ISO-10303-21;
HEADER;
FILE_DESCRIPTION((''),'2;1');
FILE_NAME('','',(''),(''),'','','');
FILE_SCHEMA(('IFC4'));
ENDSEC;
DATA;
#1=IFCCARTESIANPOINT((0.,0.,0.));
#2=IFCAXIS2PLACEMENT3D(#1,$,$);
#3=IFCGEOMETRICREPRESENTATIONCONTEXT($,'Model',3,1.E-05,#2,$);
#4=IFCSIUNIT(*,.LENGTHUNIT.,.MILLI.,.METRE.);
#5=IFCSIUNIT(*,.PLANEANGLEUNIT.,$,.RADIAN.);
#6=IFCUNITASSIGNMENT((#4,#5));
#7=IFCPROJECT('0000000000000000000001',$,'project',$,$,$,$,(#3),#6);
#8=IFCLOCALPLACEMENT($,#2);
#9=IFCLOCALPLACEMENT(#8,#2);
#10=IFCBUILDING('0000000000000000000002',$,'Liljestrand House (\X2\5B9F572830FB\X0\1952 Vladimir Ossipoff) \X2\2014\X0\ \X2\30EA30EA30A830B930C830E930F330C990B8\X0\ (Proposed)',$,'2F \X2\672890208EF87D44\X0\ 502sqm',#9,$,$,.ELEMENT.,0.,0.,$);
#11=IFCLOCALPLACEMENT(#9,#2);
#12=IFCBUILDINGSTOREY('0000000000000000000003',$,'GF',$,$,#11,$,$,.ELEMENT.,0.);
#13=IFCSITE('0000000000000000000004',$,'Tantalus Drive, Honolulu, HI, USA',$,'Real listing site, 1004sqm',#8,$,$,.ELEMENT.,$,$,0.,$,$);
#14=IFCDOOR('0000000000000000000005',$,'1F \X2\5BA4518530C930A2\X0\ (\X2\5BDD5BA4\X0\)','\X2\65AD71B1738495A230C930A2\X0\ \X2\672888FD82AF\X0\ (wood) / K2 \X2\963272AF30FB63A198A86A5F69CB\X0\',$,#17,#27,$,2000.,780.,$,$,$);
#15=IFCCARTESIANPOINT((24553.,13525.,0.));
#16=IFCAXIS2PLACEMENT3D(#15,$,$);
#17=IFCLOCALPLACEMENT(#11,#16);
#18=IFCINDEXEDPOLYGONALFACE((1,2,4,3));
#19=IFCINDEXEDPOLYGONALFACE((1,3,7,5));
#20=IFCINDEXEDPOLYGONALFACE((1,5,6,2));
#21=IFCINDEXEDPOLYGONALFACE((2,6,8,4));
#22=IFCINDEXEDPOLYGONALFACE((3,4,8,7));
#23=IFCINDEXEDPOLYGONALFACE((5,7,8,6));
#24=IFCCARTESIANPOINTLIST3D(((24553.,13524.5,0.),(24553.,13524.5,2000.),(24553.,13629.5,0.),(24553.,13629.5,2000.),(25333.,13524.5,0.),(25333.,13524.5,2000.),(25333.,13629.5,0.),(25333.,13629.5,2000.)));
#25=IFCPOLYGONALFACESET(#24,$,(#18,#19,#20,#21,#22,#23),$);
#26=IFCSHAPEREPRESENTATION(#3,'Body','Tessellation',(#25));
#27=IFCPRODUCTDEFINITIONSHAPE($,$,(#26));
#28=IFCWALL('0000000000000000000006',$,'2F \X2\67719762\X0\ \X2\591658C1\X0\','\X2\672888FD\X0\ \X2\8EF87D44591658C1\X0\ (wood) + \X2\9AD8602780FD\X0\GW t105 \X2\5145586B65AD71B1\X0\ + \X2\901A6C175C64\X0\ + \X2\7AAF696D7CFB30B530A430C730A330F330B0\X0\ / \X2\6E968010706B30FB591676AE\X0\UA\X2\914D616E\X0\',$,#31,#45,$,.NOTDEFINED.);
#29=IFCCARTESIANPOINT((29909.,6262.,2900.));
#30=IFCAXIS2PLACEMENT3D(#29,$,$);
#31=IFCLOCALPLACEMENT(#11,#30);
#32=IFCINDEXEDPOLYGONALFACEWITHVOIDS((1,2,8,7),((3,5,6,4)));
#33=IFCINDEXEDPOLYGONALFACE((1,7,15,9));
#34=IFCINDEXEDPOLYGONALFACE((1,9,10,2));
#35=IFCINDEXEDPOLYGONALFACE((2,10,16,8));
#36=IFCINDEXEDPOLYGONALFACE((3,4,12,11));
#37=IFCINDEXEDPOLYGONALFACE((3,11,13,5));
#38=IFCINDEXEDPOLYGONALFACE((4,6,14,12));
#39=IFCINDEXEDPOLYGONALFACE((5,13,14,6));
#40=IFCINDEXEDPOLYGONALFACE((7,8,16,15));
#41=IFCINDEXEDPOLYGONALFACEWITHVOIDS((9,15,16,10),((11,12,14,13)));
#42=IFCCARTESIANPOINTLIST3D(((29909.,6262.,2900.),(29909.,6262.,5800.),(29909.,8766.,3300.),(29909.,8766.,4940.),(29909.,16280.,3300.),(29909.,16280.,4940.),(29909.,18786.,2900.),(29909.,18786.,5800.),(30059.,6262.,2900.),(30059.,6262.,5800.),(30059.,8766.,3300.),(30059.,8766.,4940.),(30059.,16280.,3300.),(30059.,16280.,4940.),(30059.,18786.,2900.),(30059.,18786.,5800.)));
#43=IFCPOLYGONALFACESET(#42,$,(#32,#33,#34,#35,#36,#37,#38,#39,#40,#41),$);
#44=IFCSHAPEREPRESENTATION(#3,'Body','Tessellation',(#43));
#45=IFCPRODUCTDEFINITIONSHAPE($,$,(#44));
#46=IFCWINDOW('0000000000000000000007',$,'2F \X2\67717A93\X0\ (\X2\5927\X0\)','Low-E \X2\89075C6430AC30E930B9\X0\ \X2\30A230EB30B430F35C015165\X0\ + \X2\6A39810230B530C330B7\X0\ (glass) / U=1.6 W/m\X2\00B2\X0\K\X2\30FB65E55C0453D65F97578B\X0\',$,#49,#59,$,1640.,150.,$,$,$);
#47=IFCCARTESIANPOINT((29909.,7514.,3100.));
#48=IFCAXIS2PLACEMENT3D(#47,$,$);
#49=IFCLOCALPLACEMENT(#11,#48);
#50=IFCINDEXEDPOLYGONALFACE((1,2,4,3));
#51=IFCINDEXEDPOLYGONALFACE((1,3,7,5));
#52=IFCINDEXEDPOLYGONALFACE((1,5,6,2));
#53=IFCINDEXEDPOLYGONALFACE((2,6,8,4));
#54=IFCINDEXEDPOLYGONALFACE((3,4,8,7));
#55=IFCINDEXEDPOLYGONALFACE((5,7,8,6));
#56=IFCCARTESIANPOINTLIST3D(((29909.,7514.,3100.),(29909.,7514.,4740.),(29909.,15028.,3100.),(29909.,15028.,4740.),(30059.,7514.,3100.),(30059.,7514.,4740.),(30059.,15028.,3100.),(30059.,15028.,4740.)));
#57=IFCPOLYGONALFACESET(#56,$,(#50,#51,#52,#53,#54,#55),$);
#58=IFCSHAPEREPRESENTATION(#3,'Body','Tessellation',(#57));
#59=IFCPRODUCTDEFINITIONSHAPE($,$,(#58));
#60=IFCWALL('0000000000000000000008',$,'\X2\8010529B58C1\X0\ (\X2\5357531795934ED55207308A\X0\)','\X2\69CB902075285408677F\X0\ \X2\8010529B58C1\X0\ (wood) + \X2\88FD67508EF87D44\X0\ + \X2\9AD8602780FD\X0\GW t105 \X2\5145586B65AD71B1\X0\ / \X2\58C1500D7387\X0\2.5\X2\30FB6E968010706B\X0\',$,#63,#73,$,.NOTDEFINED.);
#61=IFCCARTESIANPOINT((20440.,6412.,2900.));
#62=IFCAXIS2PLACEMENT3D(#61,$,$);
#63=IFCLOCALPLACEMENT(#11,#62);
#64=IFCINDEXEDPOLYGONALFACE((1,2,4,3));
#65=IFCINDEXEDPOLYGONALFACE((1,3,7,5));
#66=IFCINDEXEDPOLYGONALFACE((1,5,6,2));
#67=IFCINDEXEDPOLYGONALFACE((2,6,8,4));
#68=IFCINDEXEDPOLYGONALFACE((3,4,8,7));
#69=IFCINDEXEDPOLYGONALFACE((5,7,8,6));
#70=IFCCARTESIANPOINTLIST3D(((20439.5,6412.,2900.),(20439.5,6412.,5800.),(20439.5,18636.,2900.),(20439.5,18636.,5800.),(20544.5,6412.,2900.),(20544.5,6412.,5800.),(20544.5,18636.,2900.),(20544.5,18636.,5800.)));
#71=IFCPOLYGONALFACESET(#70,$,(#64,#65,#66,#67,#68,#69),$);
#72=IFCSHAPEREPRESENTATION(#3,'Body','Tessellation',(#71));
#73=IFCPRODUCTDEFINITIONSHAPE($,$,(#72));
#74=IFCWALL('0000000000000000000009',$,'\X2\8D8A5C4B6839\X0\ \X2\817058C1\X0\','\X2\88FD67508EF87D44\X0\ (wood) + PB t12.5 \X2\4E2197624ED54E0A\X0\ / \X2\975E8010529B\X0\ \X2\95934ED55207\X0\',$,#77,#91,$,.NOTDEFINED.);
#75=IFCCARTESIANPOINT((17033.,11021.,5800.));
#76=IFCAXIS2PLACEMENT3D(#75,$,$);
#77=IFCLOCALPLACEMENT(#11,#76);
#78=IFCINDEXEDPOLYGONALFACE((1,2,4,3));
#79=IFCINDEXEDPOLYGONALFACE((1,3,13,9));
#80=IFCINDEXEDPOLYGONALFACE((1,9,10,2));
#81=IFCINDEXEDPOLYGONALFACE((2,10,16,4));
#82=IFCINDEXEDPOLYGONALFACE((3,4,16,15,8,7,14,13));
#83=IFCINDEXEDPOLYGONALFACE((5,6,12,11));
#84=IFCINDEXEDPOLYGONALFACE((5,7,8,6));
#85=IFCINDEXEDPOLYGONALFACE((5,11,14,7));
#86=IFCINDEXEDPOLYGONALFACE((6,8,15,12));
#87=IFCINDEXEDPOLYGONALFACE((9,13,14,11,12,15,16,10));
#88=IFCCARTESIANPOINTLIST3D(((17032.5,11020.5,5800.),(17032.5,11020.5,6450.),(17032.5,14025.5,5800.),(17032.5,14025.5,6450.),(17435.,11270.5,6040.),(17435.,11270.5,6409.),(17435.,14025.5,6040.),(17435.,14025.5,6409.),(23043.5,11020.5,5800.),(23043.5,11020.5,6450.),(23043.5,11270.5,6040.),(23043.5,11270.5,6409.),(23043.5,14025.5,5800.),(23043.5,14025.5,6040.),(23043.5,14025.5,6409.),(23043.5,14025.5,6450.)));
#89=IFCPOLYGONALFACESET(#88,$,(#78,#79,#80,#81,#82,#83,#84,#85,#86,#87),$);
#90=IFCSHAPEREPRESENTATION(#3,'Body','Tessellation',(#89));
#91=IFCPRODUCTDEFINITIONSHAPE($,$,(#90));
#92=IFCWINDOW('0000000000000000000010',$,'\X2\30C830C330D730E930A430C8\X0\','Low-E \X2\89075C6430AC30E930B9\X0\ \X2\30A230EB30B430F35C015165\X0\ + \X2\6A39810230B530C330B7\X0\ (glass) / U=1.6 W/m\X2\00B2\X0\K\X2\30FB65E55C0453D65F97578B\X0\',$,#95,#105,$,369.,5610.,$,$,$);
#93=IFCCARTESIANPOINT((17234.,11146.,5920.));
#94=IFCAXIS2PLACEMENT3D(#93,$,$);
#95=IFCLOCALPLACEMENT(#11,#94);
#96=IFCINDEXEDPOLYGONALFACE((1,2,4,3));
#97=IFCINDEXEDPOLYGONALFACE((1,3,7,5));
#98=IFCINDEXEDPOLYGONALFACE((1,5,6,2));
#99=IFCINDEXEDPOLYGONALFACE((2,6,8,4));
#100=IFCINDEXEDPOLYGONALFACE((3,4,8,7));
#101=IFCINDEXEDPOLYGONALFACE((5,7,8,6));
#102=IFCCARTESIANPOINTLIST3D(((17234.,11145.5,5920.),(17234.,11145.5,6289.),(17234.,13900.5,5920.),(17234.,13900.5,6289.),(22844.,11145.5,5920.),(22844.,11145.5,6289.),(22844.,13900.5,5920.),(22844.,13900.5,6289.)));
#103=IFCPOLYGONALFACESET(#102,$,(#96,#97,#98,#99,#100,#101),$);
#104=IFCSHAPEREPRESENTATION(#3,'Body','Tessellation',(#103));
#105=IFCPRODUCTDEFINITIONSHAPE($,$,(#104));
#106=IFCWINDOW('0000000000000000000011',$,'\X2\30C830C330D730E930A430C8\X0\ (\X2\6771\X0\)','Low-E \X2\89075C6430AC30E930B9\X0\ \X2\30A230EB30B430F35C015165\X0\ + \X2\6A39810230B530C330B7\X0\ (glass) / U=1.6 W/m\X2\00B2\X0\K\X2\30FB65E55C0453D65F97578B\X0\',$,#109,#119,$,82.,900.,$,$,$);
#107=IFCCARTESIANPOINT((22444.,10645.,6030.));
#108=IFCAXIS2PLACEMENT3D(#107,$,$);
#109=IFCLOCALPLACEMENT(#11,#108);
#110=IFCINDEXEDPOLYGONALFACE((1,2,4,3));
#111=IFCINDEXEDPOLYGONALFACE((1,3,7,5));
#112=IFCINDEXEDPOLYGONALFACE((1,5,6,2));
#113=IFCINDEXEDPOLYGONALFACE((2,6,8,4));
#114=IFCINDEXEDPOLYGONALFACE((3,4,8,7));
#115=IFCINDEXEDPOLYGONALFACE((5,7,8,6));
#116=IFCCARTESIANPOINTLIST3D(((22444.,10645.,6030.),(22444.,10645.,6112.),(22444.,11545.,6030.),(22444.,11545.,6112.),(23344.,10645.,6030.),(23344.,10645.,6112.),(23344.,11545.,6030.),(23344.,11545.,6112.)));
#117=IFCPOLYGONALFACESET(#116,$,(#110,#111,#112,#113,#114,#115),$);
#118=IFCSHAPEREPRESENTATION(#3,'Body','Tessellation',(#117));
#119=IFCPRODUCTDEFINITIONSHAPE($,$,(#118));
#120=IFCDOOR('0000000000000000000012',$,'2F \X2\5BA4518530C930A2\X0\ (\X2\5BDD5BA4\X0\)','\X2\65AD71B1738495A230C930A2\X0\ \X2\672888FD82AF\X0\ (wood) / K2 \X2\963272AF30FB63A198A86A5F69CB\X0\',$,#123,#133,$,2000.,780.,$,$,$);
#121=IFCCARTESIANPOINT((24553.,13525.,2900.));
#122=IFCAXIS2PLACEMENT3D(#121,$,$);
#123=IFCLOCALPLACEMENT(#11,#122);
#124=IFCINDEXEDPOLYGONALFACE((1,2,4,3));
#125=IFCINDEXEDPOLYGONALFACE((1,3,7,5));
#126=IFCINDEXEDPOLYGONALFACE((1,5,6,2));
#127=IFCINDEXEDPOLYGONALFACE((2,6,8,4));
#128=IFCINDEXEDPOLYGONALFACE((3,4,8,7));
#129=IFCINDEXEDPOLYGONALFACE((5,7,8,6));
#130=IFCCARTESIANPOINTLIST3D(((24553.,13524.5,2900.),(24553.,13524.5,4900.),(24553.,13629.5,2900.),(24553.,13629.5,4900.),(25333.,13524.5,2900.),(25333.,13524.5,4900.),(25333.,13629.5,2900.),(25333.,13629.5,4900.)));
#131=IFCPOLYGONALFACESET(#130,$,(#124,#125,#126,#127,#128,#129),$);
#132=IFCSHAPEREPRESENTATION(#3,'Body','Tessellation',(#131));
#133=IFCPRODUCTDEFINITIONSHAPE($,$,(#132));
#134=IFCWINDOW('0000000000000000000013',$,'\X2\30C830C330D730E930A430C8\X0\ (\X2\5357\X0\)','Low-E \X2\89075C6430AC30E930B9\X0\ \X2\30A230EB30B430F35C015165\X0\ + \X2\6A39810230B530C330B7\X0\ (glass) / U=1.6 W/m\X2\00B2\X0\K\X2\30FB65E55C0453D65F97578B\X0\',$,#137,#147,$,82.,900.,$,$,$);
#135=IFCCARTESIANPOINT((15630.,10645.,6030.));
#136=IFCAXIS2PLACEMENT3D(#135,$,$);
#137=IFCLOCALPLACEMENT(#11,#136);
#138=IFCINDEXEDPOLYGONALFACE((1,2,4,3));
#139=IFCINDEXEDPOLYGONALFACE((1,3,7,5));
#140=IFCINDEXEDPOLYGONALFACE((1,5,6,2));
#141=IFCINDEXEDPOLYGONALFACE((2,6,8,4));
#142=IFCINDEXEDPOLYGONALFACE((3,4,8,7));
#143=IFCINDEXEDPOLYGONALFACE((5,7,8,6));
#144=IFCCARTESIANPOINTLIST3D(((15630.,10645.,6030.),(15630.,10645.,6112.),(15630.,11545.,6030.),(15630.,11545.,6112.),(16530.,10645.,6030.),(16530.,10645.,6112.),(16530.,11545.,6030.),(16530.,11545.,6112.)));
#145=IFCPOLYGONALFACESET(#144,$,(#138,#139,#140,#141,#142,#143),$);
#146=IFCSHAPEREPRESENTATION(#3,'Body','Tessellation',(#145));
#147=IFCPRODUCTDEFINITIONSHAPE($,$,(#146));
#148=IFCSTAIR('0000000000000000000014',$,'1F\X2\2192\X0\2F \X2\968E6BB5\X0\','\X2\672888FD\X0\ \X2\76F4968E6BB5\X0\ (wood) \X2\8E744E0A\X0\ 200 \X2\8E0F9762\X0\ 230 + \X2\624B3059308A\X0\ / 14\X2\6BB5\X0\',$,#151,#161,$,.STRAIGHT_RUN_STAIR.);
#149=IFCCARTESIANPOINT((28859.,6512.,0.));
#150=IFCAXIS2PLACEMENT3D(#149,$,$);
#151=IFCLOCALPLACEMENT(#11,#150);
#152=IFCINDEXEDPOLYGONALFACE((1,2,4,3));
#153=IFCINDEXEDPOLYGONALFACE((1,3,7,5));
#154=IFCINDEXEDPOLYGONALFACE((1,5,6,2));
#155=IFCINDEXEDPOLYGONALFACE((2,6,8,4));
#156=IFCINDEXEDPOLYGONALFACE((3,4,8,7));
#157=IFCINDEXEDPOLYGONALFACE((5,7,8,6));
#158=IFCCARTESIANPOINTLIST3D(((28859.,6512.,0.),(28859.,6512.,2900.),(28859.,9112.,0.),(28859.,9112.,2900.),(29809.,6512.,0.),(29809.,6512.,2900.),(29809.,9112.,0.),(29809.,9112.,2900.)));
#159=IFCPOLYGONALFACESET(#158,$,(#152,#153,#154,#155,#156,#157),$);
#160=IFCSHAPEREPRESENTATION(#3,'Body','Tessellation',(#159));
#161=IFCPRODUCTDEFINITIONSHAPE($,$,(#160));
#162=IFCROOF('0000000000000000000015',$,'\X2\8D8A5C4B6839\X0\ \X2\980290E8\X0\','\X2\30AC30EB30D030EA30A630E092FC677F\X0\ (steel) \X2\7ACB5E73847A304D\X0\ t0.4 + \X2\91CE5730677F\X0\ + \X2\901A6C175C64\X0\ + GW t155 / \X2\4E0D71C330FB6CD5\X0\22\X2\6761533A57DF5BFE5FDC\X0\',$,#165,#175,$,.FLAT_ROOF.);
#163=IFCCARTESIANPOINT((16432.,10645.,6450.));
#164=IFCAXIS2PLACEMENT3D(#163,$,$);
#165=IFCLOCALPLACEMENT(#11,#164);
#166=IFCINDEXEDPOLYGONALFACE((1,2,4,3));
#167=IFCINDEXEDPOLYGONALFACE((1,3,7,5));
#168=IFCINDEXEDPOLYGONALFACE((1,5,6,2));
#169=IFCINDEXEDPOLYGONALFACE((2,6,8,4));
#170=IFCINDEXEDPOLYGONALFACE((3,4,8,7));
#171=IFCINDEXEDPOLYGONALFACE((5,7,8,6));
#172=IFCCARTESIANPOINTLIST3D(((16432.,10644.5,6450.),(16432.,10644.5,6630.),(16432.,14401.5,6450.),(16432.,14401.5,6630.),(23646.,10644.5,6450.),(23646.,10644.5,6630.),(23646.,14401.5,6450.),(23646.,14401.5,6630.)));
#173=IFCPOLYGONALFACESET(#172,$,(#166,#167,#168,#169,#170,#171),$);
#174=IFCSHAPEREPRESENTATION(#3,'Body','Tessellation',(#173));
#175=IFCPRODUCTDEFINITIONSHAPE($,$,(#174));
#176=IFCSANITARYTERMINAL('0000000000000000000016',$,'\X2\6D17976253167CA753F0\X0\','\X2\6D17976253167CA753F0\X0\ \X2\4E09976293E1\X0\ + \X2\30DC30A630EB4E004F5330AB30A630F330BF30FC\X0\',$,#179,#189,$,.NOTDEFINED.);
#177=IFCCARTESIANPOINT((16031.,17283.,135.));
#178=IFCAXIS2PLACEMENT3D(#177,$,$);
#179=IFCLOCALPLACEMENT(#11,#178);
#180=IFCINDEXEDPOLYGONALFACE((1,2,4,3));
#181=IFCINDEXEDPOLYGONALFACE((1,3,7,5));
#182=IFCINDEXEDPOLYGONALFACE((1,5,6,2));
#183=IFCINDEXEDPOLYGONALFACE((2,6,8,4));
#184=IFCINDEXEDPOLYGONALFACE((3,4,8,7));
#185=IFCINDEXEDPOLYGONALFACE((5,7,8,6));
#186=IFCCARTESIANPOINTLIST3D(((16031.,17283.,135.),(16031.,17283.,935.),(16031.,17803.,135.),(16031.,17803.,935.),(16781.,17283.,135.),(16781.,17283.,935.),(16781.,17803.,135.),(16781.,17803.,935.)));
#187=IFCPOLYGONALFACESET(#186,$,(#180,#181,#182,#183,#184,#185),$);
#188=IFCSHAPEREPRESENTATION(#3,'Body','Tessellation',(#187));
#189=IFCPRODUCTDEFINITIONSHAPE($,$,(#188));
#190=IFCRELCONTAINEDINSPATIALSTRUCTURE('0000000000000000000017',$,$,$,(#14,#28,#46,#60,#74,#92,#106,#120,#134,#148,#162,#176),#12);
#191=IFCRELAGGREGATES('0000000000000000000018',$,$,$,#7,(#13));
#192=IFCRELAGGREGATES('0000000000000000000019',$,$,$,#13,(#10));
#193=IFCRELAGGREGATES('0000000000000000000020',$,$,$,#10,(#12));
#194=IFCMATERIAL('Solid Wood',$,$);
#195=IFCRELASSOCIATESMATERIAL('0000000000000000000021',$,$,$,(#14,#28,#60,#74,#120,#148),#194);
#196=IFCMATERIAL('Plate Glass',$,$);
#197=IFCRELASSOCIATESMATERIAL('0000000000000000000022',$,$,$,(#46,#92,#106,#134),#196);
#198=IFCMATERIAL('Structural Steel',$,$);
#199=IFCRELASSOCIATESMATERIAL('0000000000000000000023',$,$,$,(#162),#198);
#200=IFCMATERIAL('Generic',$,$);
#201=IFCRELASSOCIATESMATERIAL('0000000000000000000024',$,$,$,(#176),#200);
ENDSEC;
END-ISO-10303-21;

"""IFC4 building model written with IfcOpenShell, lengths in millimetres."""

from ifc_helpers import new_model, si_unit, frame, frame_2d, origin, place, context, project, spatial, rectangle, extrude, material, element, fill, save


model = new_model("IFC4")

# Units and contexts
model_context = context("Model", 3, precision=1e-05, world=origin())
ifc_project = project(units=[si_unit("LENGTHUNIT", "METRE", prefix="MILLI"), si_unit("PLANEANGLEUNIT", "RADIAN")], contexts=[model_context])

# Site, building, storey
site_placement = place(None, origin())
site = spatial("IfcSite", under=ifc_project, at=site_placement, Name="Tantalus Drive, Honolulu, HI, USA", ObjectType="Real listing site, 1004sqm", CompositionType="ELEMENT", RefElevation=0.0)
building_placement = place(site_placement, origin())
building = spatial("IfcBuilding", under=site, at=building_placement, Name="Liljestrand House (実在・1952 Vladimir Ossipoff) — リリエストランド邸 (Proposed)", ObjectType="2F 木造軸組 502sqm", CompositionType="ELEMENT", ElevationOfRefHeight=0.0, ElevationOfTerrain=0.0)
storey_placement = place(building_placement, origin())
storey = spatial("IfcBuildingStorey", under=building, at=storey_placement, Name="GF", CompositionType="ELEMENT", Elevation=0.0)

# Shared definitions
ifc_material_1 = material(Name="Solid Wood")
ifc_material_2 = material(Name="Plate Glass")

# Door
door_1_placement = place(storey_placement, frame((24553.0, 13525.0, 0.0)))
element("IfcDoor", 1, at=door_1_placement, inside=storey, material=ifc_material_1, Name="1F 室内ドア (寝室)", Description="断熱玄関ドア 木製芯 (wood) / K2 防犯・採風機構", OverallHeight=2000.0, OverallWidth=780.0, context=model_context, shape_type="SweptSolid", body=[
    extrude(rectangle(XDim=780.0, YDim=105.0, at=frame_2d((390.0, 52.0))), frame((24553.0, 13525.0, 0.0)), (0.0, 0.0, 1.0), 2000.0),
])

# Wall, opening, window
wall_1_placement = place(storey_placement, frame((29909.0, 6262.0, 2900.0)))
wall_1 = element("IfcWall", 2, at=wall_1_placement, inside=storey, material=ifc_material_1, Name="2F 東面 外壁", Description="木製 軸組外壁 (wood) + 高性能GW t105 充填断熱 + 通気層 + 窯業系サイディング / 準耐火・外皮UA配慮", PredefinedType="NOTDEFINED", context=model_context, shape_type="SweptSolid", body=[
    extrude(rectangle(XDim=150.0, YDim=12524.0, at=frame_2d((75.0, 6262.0))), frame((29909.0, 6262.0, 2900.0)), (0.0, 0.0, 1.0), 2900.0),
])
opening_1_placement = place(storey_placement, frame((29909.0, 7514.0, 3100.0)))
opening_1 = element("IfcOpeningElement", 3, at=opening_1_placement, cuts=wall_1, PredefinedType="NOTDEFINED", context=model_context, shape_type="SweptSolid", body=[
    extrude(rectangle(XDim=150.0, YDim=7514.0, at=frame_2d((75.0, 3757.0))), frame((29909.0, 7514.0, 3100.0)), (0.0, 0.0, 1.0), 1640.0),
])
window_1_placement = place(storey_placement, frame((29909.0, 7514.0, 3100.0)))
window_1 = element("IfcWindow", 4, at=window_1_placement, inside=storey, material=ifc_material_2, Name="2F 東窓 (大)", Description="Low-E 複層ガラス アルゴン封入 + 樹脂サッシ (glass) / U=1.6 W/m²K・日射取得型", OverallHeight=1640.0, OverallWidth=150.0, context=model_context, shape_type="SweptSolid", body=[
    extrude(rectangle(XDim=150.0, YDim=7514.0, at=frame_2d((75.0, 3757.0))), frame((29909.0, 7514.0, 3100.0)), (0.0, 0.0, 1.0), 1640.0),
])
fill(opening_1, window_1)

# Wall
wall_2_placement = place(storey_placement, frame((20440.0, 6412.0, 2900.0)))
element("IfcWall", 5, at=wall_2_placement, inside=storey, material=ifc_material_1, Name="耐力壁 (南北間仕切り)", Description="構造用合板 耐力壁 (wood) + 製材軸組 + 高性能GW t105 充填断熱 / 壁倍率2.5・準耐火", PredefinedType="NOTDEFINED", context=model_context, shape_type="SweptSolid", body=[
    extrude(rectangle(XDim=105.0, YDim=12224.0, at=frame_2d((52.0, 6112.0))), frame((20440.0, 6412.0, 2900.0)), (0.0, 0.0, 1.0), 2900.0),
])

# Wall, openings, windows
wall_3_placement = place(storey_placement, frame((17033.0, 11021.0, 5800.0)))
wall_3 = element("IfcWall", 6, at=wall_3_placement, inside=storey, material=ifc_material_1, Name="越屋根 腰壁", Description="製材軸組 (wood) + PB t12.5 両面仕上 / 非耐力 間仕切", PredefinedType="NOTDEFINED", context=model_context, shape_type="SweptSolid", body=[
    extrude(rectangle(XDim=6011.0, YDim=3005.0, at=frame_2d((3005.0, 1502.0))), frame((17033.0, 11021.0, 5800.0)), (0.0, 0.0, 1.0), 650.0),
])
opening_2_placement = place(storey_placement, frame((17234.0, 11146.0, 5920.0)))
opening_2 = element("IfcOpeningElement", 7, at=opening_2_placement, cuts=wall_3, PredefinedType="NOTDEFINED", context=model_context, shape_type="SweptSolid", body=[
    extrude(rectangle(XDim=5610.0, YDim=2755.0, at=frame_2d((2805.0, 1377.0))), frame((17234.0, 11146.0, 5920.0)), (0.0, 0.0, 1.0), 369.0),
])
opening_3_placement = place(storey_placement, frame((22444.0, 10645.0, 6030.0)))
opening_3 = element("IfcOpeningElement", 8, at=opening_3_placement, cuts=wall_3, PredefinedType="NOTDEFINED", context=model_context, shape_type="SweptSolid", body=[
    extrude(rectangle(XDim=900.0, YDim=900.0, at=frame_2d((450.0, 450.0))), frame((22444.0, 10645.0, 6030.0)), (0.0, 0.0, 1.0), 82.0),
])
window_2_placement = place(storey_placement, frame((17234.0, 11146.0, 5920.0)))
window_2 = element("IfcWindow", 9, at=window_2_placement, inside=storey, material=ifc_material_2, Name="トップライト", Description="Low-E 複層ガラス アルゴン封入 + 樹脂サッシ (glass) / U=1.6 W/m²K・日射取得型", OverallHeight=369.0, OverallWidth=5610.0, context=model_context, shape_type="SweptSolid", body=[
    extrude(rectangle(XDim=5610.0, YDim=2755.0, at=frame_2d((2805.0, 1377.0))), frame((17234.0, 11146.0, 5920.0)), (0.0, 0.0, 1.0), 369.0),
])
fill(opening_2, window_2)
window_3_placement = place(storey_placement, frame((22444.0, 10645.0, 6030.0)))
window_3 = element("IfcWindow", 10, at=window_3_placement, inside=storey, material=ifc_material_2, Name="トップライト (東)", Description="Low-E 複層ガラス アルゴン封入 + 樹脂サッシ (glass) / U=1.6 W/m²K・日射取得型", OverallHeight=82.0, OverallWidth=900.0, context=model_context, shape_type="SweptSolid", body=[
    extrude(rectangle(XDim=900.0, YDim=900.0, at=frame_2d((450.0, 450.0))), frame((22444.0, 10645.0, 6030.0)), (0.0, 0.0, 1.0), 82.0),
])
fill(opening_3, window_3)

# Door
door_2_placement = place(storey_placement, frame((24553.0, 13525.0, 2900.0)))
element("IfcDoor", 11, at=door_2_placement, inside=storey, material=ifc_material_1, Name="2F 室内ドア (寝室)", Description="断熱玄関ドア 木製芯 (wood) / K2 防犯・採風機構", OverallHeight=2000.0, OverallWidth=780.0, context=model_context, shape_type="SweptSolid", body=[
    extrude(rectangle(XDim=780.0, YDim=105.0, at=frame_2d((390.0, 52.0))), frame((24553.0, 13525.0, 2900.0)), (0.0, 0.0, 1.0), 2000.0),
])

# Window
window_4_placement = place(storey_placement, frame((15630.0, 10645.0, 6030.0)))
element("IfcWindow", 12, at=window_4_placement, inside=storey, material=ifc_material_2, Name="トップライト (南)", Description="Low-E 複層ガラス アルゴン封入 + 樹脂サッシ (glass) / U=1.6 W/m²K・日射取得型", OverallHeight=82.0, OverallWidth=900.0, context=model_context, shape_type="SweptSolid", body=[
    extrude(rectangle(XDim=900.0, YDim=900.0, at=frame_2d((450.0, 450.0))), frame((15630.0, 10645.0, 6030.0)), (0.0, 0.0, 1.0), 82.0),
])

# Stair
stair_placement = place(storey_placement, frame((28859.0, 6512.0, 0.0)))
element("IfcStair", 13, at=stair_placement, inside=storey, material=ifc_material_1, Name="1F→2F 階段", Description="木製 直階段 (wood) 蹴上 200 踏面 230 + 手すり / 14段", PredefinedType="STRAIGHT_RUN_STAIR", context=model_context, shape_type="SweptSolid", body=[
    extrude(rectangle(XDim=950.0, YDim=2600.0, at=frame_2d((475.0, 1300.0))), frame((28859.0, 6512.0, 0.0)), (0.0, 0.0, 1.0), 2900.0),
])

# Roof
ifc_material_3 = material(Name="Structural Steel")
roof_placement = place(storey_placement, frame((16432.0, 10645.0, 6450.0)))
element("IfcRoof", 14, at=roof_placement, inside=storey, material=ifc_material_3, Name="越屋根 頂部", Description="ガルバリウム鋼板 (steel) 立平葺き t0.4 + 野地板 + 通気層 + GW t155 / 不燃・法22条区域対応", PredefinedType="FLAT_ROOF", context=model_context, shape_type="SweptSolid", body=[
    extrude(rectangle(XDim=7214.0, YDim=3757.0, at=frame_2d((3607.0, 1878.0))), frame((16432.0, 10645.0, 6450.0)), (0.0, 0.0, 1.0), 180.0),
])

# Sanitary terminal
ifc_material_4 = material(Name="Generic")
sanitary_terminal_1_placement = place(storey_placement, frame((16031.0, 17283.0, 135.0)))
element("IfcSanitaryTerminal", 15, at=sanitary_terminal_1_placement, inside=storey, material=ifc_material_4, Name="洗面化粧台", Description="洗面化粧台 三面鏡 + ボウル一体カウンター", PredefinedType="NOTDEFINED", context=model_context, shape_type="SweptSolid", body=[
    extrude(rectangle(XDim=750.0, YDim=520.0, at=frame_2d((375.0, 260.0))), frame((16031.0, 17283.0, 135.0)), (0.0, 0.0, 1.0), 800.0),
])

save(model, "model.ifc")
